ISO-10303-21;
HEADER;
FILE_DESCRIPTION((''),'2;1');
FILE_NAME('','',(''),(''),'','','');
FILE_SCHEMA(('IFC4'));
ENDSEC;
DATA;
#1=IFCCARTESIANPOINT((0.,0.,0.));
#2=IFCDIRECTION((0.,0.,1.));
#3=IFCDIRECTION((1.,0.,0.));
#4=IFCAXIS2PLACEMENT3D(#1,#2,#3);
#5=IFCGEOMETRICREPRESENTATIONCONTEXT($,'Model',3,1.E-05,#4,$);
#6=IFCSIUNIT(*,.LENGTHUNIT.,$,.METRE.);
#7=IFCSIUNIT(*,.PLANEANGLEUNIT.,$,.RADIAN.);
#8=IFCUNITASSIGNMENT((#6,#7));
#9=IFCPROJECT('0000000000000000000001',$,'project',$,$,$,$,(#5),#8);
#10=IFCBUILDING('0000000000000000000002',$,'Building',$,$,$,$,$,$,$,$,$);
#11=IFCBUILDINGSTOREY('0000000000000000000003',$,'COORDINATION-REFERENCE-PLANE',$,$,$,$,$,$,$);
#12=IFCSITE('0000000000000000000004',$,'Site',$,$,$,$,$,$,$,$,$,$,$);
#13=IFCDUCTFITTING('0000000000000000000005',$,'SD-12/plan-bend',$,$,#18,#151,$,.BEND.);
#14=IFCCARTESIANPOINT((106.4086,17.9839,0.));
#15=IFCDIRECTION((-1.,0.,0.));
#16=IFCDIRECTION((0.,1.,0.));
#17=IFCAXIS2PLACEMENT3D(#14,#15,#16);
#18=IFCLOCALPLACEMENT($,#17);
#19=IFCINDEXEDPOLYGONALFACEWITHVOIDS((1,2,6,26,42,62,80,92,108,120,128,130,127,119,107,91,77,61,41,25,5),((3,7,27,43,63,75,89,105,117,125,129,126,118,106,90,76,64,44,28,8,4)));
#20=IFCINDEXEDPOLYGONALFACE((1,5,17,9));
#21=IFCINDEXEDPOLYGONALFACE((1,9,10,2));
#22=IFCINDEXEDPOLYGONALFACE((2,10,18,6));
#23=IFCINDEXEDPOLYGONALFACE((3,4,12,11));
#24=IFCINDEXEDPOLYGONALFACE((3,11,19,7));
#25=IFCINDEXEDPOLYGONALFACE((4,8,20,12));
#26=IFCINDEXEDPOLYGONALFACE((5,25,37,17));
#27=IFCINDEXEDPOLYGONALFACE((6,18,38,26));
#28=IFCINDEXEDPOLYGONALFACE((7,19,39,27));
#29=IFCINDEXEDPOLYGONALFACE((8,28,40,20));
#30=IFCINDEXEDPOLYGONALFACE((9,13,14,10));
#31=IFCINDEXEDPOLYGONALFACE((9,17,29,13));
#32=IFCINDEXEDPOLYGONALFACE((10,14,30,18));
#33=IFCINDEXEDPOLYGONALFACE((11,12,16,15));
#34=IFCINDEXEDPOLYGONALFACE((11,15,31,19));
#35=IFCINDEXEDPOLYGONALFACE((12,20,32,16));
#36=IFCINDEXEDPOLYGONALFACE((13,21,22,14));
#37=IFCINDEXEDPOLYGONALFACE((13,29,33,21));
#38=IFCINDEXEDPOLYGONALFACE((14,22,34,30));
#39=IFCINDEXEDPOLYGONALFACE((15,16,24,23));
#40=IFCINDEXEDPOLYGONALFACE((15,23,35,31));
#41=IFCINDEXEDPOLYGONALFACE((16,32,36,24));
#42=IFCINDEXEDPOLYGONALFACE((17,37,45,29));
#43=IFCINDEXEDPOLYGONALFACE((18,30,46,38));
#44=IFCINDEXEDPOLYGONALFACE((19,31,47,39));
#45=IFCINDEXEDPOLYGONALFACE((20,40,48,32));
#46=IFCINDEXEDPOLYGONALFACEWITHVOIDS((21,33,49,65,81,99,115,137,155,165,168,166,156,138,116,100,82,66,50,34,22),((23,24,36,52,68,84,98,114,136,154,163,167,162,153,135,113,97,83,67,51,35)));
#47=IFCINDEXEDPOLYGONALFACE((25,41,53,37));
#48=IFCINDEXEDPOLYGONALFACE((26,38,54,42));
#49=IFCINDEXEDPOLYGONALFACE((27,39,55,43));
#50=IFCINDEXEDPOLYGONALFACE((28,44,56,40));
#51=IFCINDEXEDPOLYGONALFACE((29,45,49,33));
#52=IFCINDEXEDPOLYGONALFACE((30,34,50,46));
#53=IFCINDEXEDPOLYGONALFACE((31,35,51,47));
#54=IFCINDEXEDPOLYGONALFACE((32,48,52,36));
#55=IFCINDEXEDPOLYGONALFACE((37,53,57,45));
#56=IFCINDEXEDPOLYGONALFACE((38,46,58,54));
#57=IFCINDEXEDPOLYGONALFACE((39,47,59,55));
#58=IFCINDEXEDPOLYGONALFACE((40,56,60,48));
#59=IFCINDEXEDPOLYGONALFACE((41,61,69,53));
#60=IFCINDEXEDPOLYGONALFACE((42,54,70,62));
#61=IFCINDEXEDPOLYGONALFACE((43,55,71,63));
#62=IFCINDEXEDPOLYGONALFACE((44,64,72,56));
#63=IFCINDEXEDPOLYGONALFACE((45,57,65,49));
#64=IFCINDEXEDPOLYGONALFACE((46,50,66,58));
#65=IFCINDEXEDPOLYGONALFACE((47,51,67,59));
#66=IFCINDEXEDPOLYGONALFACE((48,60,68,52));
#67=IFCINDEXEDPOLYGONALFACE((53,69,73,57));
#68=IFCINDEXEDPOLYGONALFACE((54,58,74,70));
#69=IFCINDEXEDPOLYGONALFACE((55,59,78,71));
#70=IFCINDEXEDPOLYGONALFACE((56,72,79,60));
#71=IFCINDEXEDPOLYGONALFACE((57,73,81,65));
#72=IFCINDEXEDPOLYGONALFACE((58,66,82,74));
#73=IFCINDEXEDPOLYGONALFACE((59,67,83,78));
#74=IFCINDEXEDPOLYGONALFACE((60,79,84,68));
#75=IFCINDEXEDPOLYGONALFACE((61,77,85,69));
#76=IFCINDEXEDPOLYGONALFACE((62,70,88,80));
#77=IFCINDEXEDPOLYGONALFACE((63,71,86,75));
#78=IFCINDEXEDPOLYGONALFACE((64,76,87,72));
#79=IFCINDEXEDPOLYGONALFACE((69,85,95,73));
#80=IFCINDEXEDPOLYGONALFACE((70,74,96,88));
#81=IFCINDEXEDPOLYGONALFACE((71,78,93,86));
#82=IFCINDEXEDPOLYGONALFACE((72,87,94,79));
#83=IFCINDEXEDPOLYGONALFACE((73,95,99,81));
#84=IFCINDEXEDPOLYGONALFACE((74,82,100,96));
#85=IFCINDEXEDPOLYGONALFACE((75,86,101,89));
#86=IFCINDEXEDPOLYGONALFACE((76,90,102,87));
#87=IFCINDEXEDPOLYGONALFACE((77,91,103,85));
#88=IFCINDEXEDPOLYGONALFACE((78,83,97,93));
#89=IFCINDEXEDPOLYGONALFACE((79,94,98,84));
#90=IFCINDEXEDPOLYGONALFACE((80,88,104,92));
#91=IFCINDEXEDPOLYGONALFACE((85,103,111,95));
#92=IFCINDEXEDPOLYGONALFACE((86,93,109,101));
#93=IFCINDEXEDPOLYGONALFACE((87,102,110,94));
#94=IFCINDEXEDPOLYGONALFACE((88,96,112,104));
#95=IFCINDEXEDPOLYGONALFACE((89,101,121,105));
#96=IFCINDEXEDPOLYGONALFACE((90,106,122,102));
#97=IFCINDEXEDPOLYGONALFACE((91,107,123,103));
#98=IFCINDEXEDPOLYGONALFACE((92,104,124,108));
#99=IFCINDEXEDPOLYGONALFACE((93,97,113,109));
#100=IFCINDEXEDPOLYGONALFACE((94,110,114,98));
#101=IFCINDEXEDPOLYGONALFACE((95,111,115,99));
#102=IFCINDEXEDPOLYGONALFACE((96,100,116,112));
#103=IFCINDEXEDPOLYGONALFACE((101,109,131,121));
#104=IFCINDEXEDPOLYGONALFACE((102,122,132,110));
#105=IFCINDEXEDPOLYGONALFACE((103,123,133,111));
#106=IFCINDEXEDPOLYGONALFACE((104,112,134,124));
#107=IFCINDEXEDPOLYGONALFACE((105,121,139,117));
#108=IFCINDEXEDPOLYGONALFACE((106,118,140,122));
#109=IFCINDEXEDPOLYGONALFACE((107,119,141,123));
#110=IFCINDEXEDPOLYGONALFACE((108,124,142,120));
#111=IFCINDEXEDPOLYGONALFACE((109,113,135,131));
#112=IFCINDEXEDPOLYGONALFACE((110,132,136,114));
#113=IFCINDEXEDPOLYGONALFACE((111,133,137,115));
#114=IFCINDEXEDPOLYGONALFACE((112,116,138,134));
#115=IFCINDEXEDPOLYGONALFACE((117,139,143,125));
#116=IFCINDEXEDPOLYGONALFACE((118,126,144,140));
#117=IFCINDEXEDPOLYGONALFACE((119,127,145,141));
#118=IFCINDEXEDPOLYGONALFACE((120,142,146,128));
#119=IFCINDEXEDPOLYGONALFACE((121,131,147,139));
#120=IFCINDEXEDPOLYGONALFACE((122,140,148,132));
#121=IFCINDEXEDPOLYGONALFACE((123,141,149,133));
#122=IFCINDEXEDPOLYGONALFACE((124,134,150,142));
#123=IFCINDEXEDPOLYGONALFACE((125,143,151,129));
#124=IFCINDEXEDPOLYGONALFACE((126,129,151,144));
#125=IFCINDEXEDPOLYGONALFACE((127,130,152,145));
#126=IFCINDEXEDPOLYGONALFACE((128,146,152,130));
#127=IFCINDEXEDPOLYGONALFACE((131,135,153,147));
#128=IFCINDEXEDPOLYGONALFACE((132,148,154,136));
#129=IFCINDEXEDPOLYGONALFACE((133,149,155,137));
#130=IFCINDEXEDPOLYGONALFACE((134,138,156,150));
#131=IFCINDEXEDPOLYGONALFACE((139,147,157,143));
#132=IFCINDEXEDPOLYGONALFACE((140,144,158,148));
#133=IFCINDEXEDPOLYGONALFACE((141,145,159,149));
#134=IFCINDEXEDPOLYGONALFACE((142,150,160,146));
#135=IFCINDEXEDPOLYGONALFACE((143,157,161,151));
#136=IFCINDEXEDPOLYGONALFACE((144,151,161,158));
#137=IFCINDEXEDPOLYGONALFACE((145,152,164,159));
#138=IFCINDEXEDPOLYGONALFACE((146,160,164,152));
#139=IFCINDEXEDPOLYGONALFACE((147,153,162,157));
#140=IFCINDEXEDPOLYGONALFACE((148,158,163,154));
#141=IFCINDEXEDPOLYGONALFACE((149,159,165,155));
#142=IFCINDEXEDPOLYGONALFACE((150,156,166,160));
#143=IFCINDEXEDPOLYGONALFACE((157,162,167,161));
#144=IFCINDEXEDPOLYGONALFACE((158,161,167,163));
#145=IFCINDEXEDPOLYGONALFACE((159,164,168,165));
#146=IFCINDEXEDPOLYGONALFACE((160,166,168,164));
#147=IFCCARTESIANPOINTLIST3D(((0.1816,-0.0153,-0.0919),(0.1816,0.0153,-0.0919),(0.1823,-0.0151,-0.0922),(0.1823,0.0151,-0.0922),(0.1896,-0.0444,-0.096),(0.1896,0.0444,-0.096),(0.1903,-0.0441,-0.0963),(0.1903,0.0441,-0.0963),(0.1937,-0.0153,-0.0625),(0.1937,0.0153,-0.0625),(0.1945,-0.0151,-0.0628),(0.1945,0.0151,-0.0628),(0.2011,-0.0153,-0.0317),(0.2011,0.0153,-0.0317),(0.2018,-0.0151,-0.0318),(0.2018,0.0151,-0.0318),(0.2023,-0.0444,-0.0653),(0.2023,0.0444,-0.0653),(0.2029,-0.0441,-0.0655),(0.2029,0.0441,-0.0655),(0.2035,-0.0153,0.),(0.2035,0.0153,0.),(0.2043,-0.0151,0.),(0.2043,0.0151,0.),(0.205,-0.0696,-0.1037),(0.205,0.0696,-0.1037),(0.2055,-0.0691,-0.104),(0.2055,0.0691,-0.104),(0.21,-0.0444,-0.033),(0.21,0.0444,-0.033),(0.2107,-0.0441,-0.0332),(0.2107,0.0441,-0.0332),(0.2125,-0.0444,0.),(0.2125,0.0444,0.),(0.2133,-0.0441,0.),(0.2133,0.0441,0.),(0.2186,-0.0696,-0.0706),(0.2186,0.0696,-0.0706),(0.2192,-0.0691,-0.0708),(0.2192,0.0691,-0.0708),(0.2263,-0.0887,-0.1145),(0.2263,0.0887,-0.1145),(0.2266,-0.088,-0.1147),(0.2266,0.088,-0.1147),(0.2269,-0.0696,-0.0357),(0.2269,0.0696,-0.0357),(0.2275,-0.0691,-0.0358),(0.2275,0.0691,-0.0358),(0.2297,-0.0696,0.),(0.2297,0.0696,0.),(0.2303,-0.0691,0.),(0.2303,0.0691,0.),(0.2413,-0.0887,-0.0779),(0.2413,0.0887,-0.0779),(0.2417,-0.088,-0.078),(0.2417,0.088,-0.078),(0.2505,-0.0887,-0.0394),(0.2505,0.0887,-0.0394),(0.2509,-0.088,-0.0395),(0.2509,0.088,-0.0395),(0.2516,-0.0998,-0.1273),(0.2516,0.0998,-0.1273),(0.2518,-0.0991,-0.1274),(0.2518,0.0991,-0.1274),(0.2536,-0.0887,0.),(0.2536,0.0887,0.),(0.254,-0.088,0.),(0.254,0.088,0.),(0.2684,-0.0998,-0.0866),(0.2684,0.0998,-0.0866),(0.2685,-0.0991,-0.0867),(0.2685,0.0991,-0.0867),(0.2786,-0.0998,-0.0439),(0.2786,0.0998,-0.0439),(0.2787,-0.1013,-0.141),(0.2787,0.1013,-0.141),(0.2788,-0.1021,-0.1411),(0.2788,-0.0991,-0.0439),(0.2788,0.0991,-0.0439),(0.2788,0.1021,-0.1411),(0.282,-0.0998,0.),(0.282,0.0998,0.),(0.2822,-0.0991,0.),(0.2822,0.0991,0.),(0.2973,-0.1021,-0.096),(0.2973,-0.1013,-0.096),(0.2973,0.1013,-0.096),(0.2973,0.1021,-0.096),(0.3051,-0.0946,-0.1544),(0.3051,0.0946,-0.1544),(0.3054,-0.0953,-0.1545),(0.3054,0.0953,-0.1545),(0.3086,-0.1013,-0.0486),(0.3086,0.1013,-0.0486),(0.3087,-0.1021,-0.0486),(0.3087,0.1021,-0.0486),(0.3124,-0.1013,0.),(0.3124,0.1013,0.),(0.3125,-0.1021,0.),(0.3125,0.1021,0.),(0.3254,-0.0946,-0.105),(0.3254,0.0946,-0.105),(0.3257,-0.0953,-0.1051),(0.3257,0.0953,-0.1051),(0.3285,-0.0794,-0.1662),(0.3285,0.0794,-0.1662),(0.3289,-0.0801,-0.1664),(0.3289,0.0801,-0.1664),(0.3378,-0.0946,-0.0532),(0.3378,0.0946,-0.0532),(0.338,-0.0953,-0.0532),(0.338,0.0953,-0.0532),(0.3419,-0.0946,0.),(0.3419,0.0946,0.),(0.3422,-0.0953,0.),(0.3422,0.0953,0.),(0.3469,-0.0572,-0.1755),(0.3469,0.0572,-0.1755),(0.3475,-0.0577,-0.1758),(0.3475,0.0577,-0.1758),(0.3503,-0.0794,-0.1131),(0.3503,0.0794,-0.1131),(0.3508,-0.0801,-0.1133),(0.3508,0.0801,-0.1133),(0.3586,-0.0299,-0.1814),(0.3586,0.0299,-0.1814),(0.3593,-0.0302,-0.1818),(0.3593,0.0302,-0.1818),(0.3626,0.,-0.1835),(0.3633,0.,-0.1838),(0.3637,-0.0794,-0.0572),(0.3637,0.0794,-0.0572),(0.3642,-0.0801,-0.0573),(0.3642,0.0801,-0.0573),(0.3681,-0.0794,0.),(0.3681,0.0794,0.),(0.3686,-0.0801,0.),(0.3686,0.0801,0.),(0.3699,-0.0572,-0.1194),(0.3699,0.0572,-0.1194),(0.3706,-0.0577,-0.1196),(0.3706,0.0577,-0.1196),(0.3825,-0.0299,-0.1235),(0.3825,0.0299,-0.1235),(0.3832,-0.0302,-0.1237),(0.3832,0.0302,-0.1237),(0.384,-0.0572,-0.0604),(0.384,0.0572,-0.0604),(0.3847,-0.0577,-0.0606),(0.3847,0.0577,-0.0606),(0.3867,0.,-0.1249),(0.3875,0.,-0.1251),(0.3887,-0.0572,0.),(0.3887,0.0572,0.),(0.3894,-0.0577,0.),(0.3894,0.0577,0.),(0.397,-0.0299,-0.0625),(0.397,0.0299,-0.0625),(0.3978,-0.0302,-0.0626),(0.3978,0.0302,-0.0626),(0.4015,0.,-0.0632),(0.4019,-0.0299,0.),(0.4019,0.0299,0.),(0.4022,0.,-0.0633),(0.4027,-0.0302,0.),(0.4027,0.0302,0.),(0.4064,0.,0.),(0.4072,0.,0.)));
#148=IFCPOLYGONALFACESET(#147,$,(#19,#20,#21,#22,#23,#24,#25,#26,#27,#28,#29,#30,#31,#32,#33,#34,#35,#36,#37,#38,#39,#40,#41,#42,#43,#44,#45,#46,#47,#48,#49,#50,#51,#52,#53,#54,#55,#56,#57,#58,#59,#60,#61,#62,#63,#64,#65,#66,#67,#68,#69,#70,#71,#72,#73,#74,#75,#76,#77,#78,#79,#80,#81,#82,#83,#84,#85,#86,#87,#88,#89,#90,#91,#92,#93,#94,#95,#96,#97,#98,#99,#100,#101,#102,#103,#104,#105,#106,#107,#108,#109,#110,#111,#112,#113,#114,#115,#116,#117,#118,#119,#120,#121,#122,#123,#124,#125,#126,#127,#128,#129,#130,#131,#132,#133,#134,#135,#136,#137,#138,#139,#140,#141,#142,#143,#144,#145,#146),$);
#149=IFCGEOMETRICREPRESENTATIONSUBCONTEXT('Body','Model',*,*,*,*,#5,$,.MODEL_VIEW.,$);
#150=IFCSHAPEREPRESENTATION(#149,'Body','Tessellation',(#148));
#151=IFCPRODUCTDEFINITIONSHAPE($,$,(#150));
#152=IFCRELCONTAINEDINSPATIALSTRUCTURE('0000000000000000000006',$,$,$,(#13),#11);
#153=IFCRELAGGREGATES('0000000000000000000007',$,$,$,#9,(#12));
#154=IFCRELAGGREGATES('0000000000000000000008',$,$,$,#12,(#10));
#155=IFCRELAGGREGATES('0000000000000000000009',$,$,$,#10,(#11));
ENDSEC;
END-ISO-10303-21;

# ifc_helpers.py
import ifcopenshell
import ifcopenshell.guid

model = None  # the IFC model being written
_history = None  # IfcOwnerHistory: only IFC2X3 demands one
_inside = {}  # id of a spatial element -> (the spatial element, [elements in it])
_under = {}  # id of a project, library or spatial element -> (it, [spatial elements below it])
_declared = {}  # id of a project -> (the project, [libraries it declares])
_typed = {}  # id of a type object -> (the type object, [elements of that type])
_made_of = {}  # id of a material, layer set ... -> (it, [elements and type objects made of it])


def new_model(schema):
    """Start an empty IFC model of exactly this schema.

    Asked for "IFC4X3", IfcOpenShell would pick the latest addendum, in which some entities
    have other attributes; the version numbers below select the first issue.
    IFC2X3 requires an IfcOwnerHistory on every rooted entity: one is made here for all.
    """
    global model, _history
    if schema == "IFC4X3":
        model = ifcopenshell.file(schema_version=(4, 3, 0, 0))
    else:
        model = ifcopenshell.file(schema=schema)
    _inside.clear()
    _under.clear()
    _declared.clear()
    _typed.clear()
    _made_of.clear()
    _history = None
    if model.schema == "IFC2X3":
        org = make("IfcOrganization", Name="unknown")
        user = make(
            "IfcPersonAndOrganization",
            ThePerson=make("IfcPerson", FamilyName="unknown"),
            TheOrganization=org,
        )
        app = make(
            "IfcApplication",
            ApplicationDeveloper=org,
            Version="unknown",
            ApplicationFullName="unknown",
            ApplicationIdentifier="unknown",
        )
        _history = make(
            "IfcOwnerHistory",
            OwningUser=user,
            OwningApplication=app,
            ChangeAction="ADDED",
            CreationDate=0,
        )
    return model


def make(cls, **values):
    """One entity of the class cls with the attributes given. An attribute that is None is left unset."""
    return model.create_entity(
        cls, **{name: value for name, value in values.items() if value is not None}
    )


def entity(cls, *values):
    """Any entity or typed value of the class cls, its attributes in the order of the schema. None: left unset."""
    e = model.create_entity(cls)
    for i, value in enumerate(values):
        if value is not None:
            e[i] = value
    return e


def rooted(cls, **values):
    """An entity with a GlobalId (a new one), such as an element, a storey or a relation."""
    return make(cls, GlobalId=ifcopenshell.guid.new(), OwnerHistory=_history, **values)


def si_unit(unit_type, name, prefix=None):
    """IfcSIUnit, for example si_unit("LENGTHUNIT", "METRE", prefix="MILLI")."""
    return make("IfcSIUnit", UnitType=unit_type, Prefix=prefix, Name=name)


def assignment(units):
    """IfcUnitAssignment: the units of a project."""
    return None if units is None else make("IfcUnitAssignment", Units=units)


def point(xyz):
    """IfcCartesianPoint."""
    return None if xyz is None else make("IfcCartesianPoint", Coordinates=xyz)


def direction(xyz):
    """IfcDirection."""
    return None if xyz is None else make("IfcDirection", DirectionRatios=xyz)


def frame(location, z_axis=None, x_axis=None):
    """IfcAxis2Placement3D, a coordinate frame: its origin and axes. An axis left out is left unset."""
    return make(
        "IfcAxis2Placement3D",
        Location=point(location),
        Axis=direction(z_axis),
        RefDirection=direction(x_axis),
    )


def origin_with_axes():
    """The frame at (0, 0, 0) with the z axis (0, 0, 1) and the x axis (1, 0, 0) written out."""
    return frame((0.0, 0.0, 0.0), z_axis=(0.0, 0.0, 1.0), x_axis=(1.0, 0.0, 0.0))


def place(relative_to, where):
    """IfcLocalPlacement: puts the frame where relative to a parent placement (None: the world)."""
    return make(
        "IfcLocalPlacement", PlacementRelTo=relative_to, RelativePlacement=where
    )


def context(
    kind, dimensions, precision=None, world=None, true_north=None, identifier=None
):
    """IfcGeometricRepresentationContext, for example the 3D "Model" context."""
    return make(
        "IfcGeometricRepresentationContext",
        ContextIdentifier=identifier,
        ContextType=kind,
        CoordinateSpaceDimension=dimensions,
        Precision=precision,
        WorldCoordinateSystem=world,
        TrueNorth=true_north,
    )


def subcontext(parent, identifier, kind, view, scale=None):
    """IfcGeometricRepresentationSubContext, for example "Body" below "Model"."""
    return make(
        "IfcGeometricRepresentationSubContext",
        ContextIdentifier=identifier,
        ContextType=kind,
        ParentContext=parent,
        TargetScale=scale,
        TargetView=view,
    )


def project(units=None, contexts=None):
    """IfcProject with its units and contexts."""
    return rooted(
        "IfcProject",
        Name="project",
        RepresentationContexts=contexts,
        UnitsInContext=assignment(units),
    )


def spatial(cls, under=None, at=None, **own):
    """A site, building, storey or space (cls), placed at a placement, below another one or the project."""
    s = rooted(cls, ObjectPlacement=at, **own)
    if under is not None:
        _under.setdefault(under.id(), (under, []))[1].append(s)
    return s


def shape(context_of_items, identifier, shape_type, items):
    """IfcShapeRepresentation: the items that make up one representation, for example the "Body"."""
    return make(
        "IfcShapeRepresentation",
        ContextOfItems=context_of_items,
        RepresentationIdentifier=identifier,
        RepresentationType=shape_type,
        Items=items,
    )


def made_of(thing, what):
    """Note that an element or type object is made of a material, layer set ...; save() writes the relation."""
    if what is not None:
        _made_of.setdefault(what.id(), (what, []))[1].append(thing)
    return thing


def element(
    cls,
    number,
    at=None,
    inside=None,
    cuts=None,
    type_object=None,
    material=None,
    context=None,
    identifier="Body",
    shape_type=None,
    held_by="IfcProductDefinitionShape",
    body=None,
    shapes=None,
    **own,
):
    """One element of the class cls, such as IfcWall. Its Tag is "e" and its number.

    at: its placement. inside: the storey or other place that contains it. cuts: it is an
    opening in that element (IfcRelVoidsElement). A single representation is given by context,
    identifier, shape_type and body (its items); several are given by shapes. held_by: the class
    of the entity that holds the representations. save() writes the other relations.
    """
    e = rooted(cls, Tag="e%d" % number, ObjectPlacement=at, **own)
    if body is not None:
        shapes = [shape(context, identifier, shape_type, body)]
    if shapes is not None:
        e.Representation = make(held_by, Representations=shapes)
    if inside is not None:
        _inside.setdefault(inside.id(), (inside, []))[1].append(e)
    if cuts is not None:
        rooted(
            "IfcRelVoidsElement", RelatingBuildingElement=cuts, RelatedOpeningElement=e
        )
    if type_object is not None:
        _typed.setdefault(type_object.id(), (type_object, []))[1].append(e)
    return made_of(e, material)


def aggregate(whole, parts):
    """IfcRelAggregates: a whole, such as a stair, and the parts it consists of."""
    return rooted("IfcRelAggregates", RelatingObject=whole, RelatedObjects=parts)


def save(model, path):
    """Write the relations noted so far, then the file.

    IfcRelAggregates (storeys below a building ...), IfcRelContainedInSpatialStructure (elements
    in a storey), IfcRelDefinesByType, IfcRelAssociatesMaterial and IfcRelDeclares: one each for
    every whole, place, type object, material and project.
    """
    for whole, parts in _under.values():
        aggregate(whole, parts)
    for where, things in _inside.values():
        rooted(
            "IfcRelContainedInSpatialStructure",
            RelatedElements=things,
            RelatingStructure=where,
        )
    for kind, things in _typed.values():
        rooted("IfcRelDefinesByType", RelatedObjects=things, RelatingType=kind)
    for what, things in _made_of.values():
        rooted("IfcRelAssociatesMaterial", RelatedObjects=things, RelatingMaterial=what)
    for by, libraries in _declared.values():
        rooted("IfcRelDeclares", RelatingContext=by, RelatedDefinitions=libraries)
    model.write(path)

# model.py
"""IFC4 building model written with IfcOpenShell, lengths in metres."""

from ifc_helpers import new_model, entity, si_unit, frame, origin_with_axes, place, context, subcontext, project, spatial, element, save


model = new_model("IFC4")

# Units and contexts
model_context = context("Model", 3, precision=1e-05, world=origin_with_axes())
body_context_1 = subcontext(model_context, "Body", "Model", "MODEL_VIEW")
ifc_project = project(units=[si_unit("LENGTHUNIT", "METRE"), si_unit("PLANEANGLEUNIT", "RADIAN")], contexts=[model_context])

# Site, building, storey
site = spatial("IfcSite", under=ifc_project, Name="Site")
building = spatial("IfcBuilding", under=site, Name="Building")
storey = spatial("IfcBuildingStorey", under=building, Name="COORDINATION-REFERENCE-PLANE")

# Duct fitting
duct_fitting_1_placement = place(None, frame((106.4086, 17.9839, 0.0), z_axis=(-1.0, 0.0, 0.0), x_axis=(0.0, 1.0, 0.0)))
element("IfcDuctFitting", 1, at=duct_fitting_1_placement, inside=storey, Name="SD-12/plan-bend", PredefinedType="BEND", context=body_context_1, shape_type="SweptSolid", body=[
    entity("IfcRevolvedAreaSolid", entity("IfcCircleHollowProfileDef", "AREA", None, entity("IfcAxis2Placement2D", entity("IfcCartesianPoint", [0.3048, 0.0])), 0.1024, 0.0008), entity("IfcAxis2Placement3D", entity("IfcCartesianPoint", [0.0, 0.0, 0.0]), entity("IfcDirection", [0.0, 0.0, 1.0]), entity("IfcDirection", [1.0, 0.0, 0.0])), entity("IfcAxis1Placement", entity("IfcCartesianPoint", [0.0, 0.0, 0.0]), entity("IfcDirection", [0.0, 1.0, 0.0])), 0.468399),
])

save(model, "model.ifc")
